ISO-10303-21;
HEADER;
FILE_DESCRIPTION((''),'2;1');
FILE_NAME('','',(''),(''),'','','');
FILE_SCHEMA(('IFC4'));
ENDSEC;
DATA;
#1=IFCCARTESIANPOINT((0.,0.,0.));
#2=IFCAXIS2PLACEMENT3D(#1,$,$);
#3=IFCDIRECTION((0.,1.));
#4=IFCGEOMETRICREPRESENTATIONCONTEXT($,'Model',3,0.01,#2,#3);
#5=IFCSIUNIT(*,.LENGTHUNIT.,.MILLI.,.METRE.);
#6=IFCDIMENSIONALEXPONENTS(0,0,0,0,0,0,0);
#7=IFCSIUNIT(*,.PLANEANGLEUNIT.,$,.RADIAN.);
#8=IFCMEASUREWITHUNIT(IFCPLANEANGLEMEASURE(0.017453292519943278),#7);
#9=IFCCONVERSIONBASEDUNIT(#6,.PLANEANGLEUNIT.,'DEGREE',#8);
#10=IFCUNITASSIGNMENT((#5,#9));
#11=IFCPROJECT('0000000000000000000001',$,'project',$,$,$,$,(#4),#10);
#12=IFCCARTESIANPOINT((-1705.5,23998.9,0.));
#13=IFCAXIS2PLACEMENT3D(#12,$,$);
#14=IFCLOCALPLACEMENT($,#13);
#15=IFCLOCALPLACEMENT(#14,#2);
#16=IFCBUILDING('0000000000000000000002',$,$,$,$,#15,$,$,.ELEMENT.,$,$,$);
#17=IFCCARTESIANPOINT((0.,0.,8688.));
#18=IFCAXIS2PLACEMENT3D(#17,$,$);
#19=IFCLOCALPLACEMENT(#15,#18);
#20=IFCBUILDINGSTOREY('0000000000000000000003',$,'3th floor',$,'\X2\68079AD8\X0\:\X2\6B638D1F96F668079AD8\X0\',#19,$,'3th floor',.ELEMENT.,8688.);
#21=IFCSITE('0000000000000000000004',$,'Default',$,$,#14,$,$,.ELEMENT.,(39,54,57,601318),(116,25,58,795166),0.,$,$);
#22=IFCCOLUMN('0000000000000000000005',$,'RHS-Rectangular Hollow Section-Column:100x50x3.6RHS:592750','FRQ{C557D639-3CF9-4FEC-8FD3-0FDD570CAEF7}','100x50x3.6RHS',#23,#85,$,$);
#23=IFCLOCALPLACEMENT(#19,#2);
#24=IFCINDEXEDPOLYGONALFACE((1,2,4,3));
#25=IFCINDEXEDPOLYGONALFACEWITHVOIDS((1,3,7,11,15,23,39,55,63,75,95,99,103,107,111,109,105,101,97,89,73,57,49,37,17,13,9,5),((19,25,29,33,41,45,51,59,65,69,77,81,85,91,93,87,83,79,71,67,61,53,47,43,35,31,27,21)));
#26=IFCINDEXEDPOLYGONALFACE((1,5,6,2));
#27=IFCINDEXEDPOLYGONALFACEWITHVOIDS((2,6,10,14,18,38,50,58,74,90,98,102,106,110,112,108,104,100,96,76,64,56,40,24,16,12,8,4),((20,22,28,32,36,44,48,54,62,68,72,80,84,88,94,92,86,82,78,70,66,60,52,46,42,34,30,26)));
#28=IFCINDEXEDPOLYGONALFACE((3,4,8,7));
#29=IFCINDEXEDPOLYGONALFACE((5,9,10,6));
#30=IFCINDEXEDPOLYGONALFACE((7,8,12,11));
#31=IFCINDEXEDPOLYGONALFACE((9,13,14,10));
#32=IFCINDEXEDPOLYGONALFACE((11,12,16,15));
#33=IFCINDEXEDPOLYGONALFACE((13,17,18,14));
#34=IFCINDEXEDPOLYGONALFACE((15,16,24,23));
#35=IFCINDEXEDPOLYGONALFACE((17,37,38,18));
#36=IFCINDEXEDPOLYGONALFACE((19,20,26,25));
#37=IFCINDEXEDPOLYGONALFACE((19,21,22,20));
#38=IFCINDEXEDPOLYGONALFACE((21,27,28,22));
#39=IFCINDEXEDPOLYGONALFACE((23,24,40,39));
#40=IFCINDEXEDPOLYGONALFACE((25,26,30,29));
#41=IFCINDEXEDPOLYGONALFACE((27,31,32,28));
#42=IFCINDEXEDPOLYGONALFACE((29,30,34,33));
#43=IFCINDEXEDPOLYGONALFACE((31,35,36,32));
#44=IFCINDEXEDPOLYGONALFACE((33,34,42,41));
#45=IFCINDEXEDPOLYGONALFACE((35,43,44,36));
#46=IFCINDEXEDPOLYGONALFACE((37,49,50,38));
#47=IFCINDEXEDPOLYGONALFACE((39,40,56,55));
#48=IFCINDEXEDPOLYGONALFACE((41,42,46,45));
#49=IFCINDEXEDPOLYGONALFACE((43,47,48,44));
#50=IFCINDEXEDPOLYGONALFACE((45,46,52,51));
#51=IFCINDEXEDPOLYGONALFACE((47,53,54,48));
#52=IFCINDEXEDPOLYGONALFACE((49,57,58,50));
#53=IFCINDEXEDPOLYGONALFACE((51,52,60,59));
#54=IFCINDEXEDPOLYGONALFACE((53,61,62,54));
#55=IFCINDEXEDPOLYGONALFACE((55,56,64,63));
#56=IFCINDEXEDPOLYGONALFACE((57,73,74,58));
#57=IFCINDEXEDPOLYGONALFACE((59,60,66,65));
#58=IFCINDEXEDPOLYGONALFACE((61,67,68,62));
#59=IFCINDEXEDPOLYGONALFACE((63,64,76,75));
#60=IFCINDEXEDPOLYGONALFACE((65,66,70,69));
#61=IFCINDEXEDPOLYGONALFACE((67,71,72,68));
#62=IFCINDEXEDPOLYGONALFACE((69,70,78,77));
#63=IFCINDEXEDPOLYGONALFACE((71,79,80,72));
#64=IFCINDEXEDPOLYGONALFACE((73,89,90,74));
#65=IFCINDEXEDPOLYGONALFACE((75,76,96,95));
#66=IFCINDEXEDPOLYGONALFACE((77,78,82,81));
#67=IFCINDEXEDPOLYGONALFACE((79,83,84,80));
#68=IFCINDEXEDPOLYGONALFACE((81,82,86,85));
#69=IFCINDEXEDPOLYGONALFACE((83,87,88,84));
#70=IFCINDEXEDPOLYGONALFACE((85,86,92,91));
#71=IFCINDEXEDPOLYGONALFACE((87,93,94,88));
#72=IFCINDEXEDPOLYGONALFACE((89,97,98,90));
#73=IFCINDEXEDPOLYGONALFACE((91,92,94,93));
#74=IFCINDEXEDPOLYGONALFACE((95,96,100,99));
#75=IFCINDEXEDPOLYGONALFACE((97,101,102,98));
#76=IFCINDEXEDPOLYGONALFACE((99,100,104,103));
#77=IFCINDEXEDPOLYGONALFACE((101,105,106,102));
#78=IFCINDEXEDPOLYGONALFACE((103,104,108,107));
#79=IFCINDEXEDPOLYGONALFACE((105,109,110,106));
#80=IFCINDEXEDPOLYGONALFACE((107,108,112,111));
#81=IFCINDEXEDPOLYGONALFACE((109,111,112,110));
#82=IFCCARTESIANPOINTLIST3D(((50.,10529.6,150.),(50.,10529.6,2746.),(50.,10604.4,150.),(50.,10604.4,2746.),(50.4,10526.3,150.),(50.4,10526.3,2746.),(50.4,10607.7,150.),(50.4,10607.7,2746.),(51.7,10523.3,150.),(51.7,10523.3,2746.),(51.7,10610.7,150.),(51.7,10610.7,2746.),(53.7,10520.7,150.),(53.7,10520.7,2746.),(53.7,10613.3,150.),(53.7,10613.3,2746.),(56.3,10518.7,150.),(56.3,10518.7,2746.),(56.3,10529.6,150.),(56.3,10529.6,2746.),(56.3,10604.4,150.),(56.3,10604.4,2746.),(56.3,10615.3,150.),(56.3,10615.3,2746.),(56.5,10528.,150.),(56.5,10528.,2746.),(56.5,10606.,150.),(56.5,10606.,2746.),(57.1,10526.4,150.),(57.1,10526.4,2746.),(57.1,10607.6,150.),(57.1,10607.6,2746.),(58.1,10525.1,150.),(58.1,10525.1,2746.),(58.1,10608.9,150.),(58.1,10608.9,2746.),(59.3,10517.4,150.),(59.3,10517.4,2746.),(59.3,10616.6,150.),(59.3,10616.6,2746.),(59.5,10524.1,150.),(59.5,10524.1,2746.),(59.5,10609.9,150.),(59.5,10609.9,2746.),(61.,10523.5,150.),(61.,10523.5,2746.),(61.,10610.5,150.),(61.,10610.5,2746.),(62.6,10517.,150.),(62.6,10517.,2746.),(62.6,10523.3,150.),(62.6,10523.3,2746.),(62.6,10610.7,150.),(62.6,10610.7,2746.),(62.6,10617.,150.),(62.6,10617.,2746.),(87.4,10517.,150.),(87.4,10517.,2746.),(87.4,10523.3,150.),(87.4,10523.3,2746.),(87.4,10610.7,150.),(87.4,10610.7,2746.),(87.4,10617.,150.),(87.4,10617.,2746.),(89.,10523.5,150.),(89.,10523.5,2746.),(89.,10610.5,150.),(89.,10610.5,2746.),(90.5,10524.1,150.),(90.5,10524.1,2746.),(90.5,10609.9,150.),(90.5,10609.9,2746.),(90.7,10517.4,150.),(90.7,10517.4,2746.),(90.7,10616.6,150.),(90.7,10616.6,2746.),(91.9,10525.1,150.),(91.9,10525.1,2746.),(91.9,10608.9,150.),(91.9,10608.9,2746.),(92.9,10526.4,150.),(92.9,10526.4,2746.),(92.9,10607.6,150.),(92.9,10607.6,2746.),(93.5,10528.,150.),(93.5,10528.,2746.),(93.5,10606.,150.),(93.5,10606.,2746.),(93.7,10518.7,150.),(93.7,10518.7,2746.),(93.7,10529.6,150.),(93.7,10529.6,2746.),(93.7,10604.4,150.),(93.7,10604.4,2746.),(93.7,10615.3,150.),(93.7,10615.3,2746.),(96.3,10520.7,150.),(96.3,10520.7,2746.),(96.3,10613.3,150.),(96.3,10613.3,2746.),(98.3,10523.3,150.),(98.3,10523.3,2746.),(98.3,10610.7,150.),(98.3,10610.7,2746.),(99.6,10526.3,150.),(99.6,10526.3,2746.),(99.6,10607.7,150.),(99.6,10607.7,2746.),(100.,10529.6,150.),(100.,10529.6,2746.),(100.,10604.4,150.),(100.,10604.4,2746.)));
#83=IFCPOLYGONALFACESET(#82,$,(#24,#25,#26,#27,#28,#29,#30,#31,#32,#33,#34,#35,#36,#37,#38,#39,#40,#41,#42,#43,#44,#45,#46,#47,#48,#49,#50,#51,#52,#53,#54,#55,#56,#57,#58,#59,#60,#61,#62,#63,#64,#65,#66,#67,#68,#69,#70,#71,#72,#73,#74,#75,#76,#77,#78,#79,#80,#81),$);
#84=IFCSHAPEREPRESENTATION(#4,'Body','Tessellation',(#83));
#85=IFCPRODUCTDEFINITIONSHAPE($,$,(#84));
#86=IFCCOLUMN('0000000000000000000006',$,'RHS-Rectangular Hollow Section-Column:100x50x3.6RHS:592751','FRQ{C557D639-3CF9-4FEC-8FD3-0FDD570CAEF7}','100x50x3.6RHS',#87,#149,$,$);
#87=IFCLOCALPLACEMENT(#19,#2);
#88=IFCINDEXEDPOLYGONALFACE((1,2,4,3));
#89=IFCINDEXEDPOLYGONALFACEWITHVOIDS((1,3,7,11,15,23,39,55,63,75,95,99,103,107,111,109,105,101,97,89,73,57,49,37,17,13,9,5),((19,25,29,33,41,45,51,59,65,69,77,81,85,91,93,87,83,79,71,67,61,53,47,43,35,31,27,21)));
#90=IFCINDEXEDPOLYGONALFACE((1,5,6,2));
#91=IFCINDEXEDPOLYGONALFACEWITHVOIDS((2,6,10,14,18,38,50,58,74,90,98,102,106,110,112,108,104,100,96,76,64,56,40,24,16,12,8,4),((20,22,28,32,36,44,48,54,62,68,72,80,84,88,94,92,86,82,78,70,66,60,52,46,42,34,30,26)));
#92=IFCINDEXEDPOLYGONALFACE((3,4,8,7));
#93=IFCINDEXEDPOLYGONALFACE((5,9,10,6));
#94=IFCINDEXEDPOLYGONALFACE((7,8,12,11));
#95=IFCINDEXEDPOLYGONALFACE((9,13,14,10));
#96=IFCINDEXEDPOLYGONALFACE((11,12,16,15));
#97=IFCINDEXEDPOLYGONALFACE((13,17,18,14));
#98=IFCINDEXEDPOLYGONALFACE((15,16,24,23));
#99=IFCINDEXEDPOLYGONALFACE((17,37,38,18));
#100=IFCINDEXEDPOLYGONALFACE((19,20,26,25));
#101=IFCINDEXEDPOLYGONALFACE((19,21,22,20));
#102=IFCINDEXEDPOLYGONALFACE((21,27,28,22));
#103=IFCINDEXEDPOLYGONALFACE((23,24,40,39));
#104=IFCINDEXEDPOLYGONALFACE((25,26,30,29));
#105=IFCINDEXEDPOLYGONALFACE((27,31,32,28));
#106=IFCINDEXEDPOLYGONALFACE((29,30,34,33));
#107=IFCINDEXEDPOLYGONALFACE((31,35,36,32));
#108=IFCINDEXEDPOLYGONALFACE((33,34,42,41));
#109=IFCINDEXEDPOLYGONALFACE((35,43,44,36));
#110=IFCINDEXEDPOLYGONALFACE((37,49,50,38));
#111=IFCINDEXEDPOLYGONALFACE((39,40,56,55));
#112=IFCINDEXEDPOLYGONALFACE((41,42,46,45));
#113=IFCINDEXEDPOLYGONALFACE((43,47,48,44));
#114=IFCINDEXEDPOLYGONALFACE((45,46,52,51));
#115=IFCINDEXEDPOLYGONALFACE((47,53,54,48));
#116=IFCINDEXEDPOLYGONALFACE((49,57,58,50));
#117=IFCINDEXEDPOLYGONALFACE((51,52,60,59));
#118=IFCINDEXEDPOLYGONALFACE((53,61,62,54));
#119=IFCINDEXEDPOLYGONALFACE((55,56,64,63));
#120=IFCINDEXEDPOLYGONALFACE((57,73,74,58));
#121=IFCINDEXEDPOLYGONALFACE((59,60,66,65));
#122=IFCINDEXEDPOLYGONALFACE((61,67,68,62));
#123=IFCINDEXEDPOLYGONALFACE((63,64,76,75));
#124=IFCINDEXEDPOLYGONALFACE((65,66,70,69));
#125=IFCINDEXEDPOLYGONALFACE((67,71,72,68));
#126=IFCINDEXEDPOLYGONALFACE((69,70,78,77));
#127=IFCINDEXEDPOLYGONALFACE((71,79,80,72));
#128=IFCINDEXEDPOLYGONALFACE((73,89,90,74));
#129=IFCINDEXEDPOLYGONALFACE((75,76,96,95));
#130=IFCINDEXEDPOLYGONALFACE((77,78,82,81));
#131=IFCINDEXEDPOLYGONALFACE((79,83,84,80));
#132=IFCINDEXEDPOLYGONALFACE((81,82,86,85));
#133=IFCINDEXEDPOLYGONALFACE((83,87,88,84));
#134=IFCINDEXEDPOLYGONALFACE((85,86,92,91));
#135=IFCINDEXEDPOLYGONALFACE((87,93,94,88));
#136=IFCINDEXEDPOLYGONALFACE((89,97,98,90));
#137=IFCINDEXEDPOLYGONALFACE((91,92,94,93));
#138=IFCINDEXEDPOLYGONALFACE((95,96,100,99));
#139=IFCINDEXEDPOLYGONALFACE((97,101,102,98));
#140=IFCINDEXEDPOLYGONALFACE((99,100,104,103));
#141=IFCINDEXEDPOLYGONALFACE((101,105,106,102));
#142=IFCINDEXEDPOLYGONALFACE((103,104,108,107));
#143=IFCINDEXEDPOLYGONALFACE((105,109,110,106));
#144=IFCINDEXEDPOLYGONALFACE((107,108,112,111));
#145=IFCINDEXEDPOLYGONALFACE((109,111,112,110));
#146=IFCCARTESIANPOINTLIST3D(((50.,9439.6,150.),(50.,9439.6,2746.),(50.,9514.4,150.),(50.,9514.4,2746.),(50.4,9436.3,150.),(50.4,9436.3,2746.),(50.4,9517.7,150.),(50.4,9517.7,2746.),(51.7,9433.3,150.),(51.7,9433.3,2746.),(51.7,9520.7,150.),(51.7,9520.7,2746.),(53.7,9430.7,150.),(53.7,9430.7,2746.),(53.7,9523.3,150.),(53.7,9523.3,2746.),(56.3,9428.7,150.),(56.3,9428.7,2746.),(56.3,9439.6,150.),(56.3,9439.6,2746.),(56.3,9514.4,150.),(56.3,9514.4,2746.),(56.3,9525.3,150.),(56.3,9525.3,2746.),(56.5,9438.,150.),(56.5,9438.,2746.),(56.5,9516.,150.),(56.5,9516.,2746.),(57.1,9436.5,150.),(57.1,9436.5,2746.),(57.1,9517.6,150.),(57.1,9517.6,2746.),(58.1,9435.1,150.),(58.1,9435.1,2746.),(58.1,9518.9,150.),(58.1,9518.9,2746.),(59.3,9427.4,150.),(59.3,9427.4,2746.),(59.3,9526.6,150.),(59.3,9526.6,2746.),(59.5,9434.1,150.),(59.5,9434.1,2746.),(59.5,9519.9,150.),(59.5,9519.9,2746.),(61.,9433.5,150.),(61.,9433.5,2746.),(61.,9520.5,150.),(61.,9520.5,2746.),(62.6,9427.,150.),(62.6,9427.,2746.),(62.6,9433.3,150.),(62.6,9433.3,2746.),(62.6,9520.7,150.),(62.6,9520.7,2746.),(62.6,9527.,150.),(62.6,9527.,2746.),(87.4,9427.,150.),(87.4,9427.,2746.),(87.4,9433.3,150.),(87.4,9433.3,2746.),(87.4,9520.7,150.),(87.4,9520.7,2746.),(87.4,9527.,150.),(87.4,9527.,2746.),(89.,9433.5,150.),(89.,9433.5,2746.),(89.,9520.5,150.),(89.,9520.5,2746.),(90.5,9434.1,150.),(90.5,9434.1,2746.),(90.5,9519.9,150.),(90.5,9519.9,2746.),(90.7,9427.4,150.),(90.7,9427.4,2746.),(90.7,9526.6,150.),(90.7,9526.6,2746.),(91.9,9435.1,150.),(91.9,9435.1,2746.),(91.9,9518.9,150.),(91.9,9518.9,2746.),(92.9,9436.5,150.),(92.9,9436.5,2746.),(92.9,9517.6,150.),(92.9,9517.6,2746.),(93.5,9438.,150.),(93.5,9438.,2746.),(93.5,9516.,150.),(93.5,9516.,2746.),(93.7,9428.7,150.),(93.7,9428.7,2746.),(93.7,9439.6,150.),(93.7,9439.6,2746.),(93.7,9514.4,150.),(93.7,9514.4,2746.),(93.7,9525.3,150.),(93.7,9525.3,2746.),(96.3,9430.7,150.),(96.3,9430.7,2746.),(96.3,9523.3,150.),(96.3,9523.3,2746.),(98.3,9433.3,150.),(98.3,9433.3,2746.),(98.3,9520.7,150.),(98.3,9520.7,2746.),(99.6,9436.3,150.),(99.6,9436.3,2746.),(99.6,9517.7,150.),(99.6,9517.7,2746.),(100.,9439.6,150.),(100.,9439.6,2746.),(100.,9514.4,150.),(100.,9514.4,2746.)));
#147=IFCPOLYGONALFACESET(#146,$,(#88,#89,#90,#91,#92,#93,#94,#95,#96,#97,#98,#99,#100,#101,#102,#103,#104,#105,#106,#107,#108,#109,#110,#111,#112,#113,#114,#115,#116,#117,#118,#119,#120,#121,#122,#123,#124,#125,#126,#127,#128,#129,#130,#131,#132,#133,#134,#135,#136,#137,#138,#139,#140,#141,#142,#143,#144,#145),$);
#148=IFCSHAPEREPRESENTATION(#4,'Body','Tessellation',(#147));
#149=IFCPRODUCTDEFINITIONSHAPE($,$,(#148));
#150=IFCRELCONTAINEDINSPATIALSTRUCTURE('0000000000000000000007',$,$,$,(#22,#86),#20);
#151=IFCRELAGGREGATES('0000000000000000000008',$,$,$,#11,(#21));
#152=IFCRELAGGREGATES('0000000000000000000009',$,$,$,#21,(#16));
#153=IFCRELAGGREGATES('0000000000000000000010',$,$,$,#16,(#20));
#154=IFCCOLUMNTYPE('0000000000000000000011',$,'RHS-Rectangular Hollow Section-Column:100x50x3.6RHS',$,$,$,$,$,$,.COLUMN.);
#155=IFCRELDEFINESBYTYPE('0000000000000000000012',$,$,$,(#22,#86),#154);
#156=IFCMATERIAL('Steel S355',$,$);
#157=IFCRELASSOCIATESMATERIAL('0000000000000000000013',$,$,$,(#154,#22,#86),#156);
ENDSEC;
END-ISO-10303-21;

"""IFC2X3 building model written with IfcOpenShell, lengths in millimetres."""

from ifc_helpers import new_model, entity, si_unit, converted_unit, point, direction, frame, frame_2d, origin, origin_2d, place, context, project, spatial, circle_curve, line_curve, trimmed, segment, composite_curve, hollow_rectangle, outline, extrude, clip, halfspace, material, type_object, element, save


model = new_model("IFC2X3")

# Units and contexts
model_context = context("Model", 3, precision=0.01, world=origin(), true_north=direction((0.0, 1.0)))
ifc_project = project(units=[si_unit("LENGTHUNIT", "METRE", prefix="MILLI"), converted_unit("PLANEANGLEUNIT", "DEGREE", entity("IfcPlaneAngleMeasure", 0.017453292519943278), si_unit("PLANEANGLEUNIT", "RADIAN"), dimensions=[0, 0, 0, 0, 0, 0, 0])], contexts=[model_context])

# Site, building, storey
site_placement = place(None, frame((-1705.5, 23998.9, 0.0)))
site = spatial("IfcSite", under=ifc_project, at=site_placement, Name="Default", CompositionType="ELEMENT", RefLatitude=(39, 54, 57, 601318), RefLongitude=(116, 25, 58, 795166), RefElevation=0.0)
building_placement = place(site_placement, origin())
building = spatial("IfcBuilding", under=site, at=building_placement, CompositionType="ELEMENT")
storey_placement = place(building_placement, frame((0.0, 0.0, 8688.0)))
storey = spatial("IfcBuildingStorey", under=building, at=storey_placement, Name="3th floor", ObjectType="标高:正负零标高", LongName="3th floor", CompositionType="ELEMENT", Elevation=8688.0)

# Columns, openings
ifc_material_1 = material(Name="Steel S355")
column_type_1 = type_object("IfcColumnType", Name="RHS-Rectangular Hollow Section-Column:100x50x3.6RHS", PredefinedType="COLUMN", material=ifc_material_1)
column_1_placement = place(storey_placement, frame((75.0, 10567.0, 2876.9)))
column_1 = element("IfcColumn", 1, at=column_1_placement, inside=storey, type_object=column_type_1, material=ifc_material_1, Name="RHS-Rectangular Hollow Section-Column:100x50x3.6RHS:592750", Description="FRQ{C557D639-3CF9-4FEC-8FD3-0FDD570CAEF7}", ObjectType="100x50x3.6RHS", context=model_context, shape_type="Clipping", body=[
    clip(clip(extrude(hollow_rectangle(XDim=50.0, YDim=100.0, WallThickness=6.3, InnerFilletRadius=6.3, OuterFilletRadius=12.6, at=origin_2d()), origin(), (0.0, 0.0, -1.0), 2782.8), halfspace(frame((-75.0, -10567.0, -55.9), z_axis=(0.0, 0.0, -1.0), x_axis=(-1.0, 0.0, 0.0)), True)), halfspace(frame((-75.0, -10567.0, -2726.9), z_axis=(0.0, 0.0, 1.0), x_axis=(1.0, 0.0, 0.0)), True)),
])
opening_1_placement = place(column_1_placement, frame((0.0, -150.1, -130.9), z_axis=(0.0, 1.0, 0.0), x_axis=(-1.0, 0.0, 0.0)))
element("IfcOpeningElement", 2, at=opening_1_placement, cuts=column_1, ObjectType="Opening", context=model_context, shape_type="SweptSolid", body=[
    extrude(outline(composite_curve([segment(trimmed(circle_curve(frame_2d((43.0, 32.0), x_axis=(1.0, 0.0)), 32.0), [point((43.0, 0.0))], [point((75.0, 32.0))], True, "CARTESIAN"), True, "CONTINUOUS"), segment(trimmed(line_curve((75.0, 32.0), (0.0, 1.0), 86.0), [point((75.0, 32.0))], [point((75.0, 118.0))], True, "CARTESIAN"), True, "CONTINUOUS"), segment(trimmed(circle_curve(frame_2d((43.0, 118.0), x_axis=(1.0, 0.0)), 32.0), [point((75.0, 118.0))], [point((43.0, 150.0))], True, "CARTESIAN"), True, "CONTINUOUS"), segment(trimmed(line_curve((43.0, 150.0), (-1.0, 0.0), 86.0), [point((43.0, 150.0))], [point((-43.0, 150.0))], True, "CARTESIAN"), True, "CONTINUOUS"), segment(trimmed(circle_curve(frame_2d((-43.0, 118.0), x_axis=(1.0, 0.0)), 32.0), [point((-43.0, 150.0))], [point((-75.0, 118.0))], True, "CARTESIAN"), True, "CONTINUOUS"), segment(trimmed(line_curve((-75.0, 118.0), (0.0, -1.0), 86.0), [point((-75.0, 118.0))], [point((-75.0, 32.0))], True, "CARTESIAN"), True, "CONTINUOUS"), segment(trimmed(circle_curve(frame_2d((-43.0, 32.0), x_axis=(1.0, 0.0)), 32.0), [point((-75.0, 32.0))], [point((-43.0, 0.0))], True, "CARTESIAN"), True, "CONTINUOUS"), segment(trimmed(line_curve((-43.0, 0.0), (1.0, 0.0), 86.0), [point((-43.0, 0.0))], [point((43.0, 0.0))], True, "CARTESIAN"), True, "CONTINUOUS")], self_intersect="UNKNOWN")), origin(), (0.0, 0.0, 1.0), 300.2),
])
column_2_placement = place(storey_placement, frame((75.0, 9477.0, 2876.9)))
column_2 = element("IfcColumn", 3, at=column_2_placement, inside=storey, type_object=column_type_1, material=ifc_material_1, Name="RHS-Rectangular Hollow Section-Column:100x50x3.6RHS:592751", Description="FRQ{C557D639-3CF9-4FEC-8FD3-0FDD570CAEF7}", ObjectType="100x50x3.6RHS", context=model_context, shape_type="Clipping", body=[
    clip(clip(extrude(hollow_rectangle(XDim=50.0, YDim=100.0, WallThickness=6.3, InnerFilletRadius=6.3, OuterFilletRadius=12.6, at=origin_2d()), origin(), (0.0, 0.0, -1.0), 2782.8), halfspace(frame((-75.0, -9477.0, -55.9), z_axis=(0.0, 0.0, -1.0), x_axis=(-1.0, 0.0, 0.0)), True)), halfspace(frame((-75.0, -9477.0, -2726.9), z_axis=(0.0, 0.0, 1.0), x_axis=(1.0, 0.0, 0.0)), True)),
])
opening_2_placement = place(column_2_placement, frame((0.0, -150.1, -130.9), z_axis=(0.0, 1.0, 0.0), x_axis=(-1.0, 0.0, 0.0)))
element("IfcOpeningElement", 4, at=opening_2_placement, cuts=column_2, ObjectType="Opening", context=model_context, shape_type="SweptSolid", body=[
    extrude(outline(composite_curve([segment(trimmed(circle_curve(frame_2d((43.0, 32.0), x_axis=(1.0, 0.0)), 32.0), [point((43.0, 0.0))], [point((75.0, 32.0))], True, "CARTESIAN"), True, "CONTINUOUS"), segment(trimmed(line_curve((75.0, 32.0), (0.0, 1.0), 86.0), [point((75.0, 32.0))], [point((75.0, 118.0))], True, "CARTESIAN"), True, "CONTINUOUS"), segment(trimmed(circle_curve(frame_2d((43.0, 118.0), x_axis=(1.0, 0.0)), 32.0), [point((75.0, 118.0))], [point((43.0, 150.0))], True, "CARTESIAN"), True, "CONTINUOUS"), segment(trimmed(line_curve((43.0, 150.0), (-1.0, 0.0), 86.0), [point((43.0, 150.0))], [point((-43.0, 150.0))], True, "CARTESIAN"), True, "CONTINUOUS"), segment(trimmed(circle_curve(frame_2d((-43.0, 118.0), x_axis=(1.0, 0.0)), 32.0), [point((-43.0, 150.0))], [point((-75.0, 118.0))], True, "CARTESIAN"), True, "CONTINUOUS"), segment(trimmed(line_curve((-75.0, 118.0), (0.0, -1.0), 86.0), [point((-75.0, 118.0))], [point((-75.0, 32.0))], True, "CARTESIAN"), True, "CONTINUOUS"), segment(trimmed(circle_curve(frame_2d((-43.0, 32.0), x_axis=(1.0, 0.0)), 32.0), [point((-75.0, 32.0))], [point((-43.0, 0.0))], True, "CARTESIAN"), True, "CONTINUOUS"), segment(trimmed(line_curve((-43.0, 0.0), (1.0, 0.0), 86.0), [point((-43.0, 0.0))], [point((43.0, 0.0))], True, "CARTESIAN"), True, "CONTINUOUS")], self_intersect="UNKNOWN")), origin(), (0.0, 0.0, 1.0), 300.2),
])

save(model, "model.ifc")
